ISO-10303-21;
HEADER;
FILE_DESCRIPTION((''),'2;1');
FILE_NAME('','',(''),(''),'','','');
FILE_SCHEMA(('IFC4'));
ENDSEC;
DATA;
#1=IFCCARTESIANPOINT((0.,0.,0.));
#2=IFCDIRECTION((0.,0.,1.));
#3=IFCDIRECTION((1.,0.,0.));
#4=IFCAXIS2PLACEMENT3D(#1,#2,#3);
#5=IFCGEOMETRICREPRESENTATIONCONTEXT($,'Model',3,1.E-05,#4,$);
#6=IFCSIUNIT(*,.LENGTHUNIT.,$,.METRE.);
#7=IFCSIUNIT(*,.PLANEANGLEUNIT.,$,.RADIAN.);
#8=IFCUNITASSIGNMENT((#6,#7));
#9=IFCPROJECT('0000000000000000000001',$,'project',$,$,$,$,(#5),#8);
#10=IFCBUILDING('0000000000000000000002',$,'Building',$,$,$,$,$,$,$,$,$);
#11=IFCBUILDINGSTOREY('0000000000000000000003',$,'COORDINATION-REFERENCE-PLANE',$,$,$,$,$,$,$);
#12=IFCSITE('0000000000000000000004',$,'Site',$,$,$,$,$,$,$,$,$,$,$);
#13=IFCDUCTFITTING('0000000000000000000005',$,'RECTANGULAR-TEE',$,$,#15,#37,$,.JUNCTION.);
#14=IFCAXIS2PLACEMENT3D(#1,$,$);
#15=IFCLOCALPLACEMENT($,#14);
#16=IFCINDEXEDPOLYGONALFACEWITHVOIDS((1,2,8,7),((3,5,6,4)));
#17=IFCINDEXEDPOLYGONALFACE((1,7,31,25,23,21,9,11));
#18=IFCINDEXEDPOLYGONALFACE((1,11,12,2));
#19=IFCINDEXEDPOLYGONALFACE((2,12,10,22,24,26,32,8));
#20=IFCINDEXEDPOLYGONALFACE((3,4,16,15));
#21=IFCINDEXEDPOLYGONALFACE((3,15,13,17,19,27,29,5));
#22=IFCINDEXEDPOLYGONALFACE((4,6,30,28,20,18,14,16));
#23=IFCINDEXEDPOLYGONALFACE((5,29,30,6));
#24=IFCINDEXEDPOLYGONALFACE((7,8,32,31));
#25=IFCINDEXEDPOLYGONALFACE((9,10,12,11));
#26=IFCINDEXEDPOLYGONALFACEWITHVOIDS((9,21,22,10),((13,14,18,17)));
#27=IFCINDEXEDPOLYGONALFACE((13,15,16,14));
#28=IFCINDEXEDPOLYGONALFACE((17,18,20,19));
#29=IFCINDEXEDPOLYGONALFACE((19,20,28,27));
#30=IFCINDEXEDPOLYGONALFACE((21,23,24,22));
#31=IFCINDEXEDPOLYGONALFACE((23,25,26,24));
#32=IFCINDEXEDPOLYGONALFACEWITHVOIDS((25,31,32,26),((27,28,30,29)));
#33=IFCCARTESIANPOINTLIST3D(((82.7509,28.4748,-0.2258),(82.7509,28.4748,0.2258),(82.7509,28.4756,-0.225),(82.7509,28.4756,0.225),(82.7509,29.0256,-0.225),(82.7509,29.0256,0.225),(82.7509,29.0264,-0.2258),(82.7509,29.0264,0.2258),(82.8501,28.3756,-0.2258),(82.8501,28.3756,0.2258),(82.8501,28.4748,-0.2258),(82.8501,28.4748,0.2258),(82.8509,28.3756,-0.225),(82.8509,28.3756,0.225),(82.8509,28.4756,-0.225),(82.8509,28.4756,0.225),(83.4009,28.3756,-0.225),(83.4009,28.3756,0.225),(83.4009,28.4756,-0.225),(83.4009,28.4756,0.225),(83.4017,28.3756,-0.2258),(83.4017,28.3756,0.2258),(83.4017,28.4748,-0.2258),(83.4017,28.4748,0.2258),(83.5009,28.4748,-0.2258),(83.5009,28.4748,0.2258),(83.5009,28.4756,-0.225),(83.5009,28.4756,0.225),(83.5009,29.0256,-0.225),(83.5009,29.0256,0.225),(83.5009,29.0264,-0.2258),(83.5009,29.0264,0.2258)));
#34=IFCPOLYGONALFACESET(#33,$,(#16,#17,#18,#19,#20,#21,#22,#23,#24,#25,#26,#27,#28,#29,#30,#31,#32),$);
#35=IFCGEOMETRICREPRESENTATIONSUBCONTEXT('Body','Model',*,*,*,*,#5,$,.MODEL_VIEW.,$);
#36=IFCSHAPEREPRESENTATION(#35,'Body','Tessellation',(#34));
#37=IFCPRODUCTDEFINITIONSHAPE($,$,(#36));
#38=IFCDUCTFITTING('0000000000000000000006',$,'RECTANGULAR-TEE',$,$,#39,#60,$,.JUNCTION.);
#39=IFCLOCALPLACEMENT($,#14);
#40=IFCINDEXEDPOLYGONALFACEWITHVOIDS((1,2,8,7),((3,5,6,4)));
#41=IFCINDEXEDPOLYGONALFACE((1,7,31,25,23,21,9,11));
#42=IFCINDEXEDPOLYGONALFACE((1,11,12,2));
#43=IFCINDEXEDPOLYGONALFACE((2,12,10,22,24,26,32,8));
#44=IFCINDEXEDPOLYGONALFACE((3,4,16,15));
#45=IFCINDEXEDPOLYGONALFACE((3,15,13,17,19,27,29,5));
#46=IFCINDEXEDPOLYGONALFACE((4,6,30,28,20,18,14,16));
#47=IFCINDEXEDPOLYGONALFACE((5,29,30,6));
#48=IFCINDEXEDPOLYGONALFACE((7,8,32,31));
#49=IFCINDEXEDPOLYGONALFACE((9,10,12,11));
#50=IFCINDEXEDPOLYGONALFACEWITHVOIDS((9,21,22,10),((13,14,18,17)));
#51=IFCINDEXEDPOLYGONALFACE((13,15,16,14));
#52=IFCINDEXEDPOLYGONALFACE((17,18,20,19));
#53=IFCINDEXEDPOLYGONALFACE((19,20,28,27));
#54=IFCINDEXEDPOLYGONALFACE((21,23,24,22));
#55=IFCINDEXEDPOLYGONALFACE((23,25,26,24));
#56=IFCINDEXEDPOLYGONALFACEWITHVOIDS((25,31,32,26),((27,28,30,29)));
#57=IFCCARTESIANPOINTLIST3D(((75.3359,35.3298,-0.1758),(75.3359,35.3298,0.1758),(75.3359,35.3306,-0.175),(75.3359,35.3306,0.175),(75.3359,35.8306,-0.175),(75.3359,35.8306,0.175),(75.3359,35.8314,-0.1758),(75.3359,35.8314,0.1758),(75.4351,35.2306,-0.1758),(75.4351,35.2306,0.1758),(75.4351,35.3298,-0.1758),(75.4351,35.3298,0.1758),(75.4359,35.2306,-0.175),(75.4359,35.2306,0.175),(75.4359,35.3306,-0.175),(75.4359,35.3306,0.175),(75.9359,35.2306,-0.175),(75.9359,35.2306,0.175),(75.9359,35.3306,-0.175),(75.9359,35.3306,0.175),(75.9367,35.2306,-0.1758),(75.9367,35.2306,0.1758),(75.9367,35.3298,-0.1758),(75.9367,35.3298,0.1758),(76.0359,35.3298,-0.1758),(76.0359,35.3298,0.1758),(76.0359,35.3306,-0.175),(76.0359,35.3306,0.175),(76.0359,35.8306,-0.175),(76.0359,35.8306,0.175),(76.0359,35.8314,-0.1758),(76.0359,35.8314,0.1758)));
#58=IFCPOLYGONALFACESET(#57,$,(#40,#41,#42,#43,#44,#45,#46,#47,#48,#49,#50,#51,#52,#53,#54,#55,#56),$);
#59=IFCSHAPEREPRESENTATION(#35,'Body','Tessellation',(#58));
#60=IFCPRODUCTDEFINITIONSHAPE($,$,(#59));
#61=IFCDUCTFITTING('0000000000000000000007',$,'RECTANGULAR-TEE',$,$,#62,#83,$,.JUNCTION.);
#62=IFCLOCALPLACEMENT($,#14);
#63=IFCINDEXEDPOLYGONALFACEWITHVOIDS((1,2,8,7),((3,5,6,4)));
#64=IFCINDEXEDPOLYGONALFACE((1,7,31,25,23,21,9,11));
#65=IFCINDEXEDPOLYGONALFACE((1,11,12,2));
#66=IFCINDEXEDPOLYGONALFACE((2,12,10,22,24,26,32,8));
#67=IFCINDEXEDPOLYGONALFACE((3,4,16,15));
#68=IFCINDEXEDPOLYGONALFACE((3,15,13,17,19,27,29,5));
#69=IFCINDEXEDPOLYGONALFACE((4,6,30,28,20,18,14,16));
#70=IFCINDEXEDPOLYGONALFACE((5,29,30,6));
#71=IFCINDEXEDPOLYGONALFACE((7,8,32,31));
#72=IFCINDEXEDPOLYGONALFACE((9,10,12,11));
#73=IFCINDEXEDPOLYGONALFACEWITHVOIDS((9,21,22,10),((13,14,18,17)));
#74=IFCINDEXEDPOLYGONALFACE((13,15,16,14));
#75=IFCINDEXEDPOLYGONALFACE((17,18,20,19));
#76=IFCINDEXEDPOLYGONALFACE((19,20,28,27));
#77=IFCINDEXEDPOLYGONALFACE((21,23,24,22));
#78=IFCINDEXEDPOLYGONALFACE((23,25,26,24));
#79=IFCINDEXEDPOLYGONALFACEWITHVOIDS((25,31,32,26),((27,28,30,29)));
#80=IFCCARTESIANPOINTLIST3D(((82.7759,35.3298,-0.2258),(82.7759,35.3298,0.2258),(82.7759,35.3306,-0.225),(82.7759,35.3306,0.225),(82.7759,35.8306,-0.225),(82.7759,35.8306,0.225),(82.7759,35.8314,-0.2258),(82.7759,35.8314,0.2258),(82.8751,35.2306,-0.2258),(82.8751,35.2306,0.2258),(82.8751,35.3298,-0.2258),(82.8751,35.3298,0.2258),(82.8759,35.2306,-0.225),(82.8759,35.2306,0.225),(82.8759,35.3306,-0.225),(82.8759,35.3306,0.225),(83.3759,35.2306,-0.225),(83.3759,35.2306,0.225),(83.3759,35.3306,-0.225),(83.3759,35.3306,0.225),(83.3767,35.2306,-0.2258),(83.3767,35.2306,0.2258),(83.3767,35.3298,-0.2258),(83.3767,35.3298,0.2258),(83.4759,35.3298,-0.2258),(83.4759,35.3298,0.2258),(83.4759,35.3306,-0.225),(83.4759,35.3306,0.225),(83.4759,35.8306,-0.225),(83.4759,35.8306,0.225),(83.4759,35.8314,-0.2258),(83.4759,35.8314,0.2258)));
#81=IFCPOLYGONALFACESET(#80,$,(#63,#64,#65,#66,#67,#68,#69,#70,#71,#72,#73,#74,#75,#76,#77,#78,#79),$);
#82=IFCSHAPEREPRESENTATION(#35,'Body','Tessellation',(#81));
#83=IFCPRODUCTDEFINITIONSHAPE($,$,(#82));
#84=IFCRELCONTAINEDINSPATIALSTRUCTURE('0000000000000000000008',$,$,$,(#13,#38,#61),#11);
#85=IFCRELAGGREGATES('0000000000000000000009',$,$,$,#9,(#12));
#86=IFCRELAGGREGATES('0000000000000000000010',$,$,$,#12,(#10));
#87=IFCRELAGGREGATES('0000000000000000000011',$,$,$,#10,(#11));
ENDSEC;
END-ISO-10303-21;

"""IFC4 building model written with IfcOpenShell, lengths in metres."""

from ifc_helpers import new_model, si_unit, frame, origin_with_axes, place, context, subcontext, project, spatial, rectangle, extrude, boolean, element, save


model = new_model("IFC4")

# Units and contexts
model_context = context("Model", 3, precision=1e-05, world=origin_with_axes())
body_context = subcontext(model_context, "Body", "Model", "MODEL_VIEW")
ifc_project = project(units=[si_unit("LENGTHUNIT", "METRE"), si_unit("PLANEANGLEUNIT", "RADIAN")], contexts=[model_context])

# Site, building, storey
site = spatial("IfcSite", under=ifc_project, Name="Site")
building = spatial("IfcBuilding", under=site, Name="Building")
storey = spatial("IfcBuildingStorey", under=building, Name="COORDINATION-REFERENCE-PLANE")

# Duct fittings
duct_fitting_1_placement = place(None, frame((83.1259, 28.7506, 0.0), z_axis=(-1.0, 0.0, 0.0), x_axis=(0.0, -1.0, 0.0)))
solid_1 = boolean("UNION", extrude(rectangle(XDim=0.55, YDim=0.45), frame((0.0, 0.0, -0.375), z_axis=(0.0, 0.0, 1.0), x_axis=(1.0, 0.0, 0.0)), (0.0, 0.0, 1.0), 0.75), extrude(rectangle(XDim=0.55, YDim=0.45), frame((0.0, 0.0, 0.0), z_axis=(1.0, 0.0, 0.0), x_axis=(0.0, 0.0, -1.0)), (0.0, 0.0, 1.0), 0.375))
element("IfcDuctFitting", 1, at=duct_fitting_1_placement, inside=storey, Name="RECTANGULAR-TEE", PredefinedType="JUNCTION", context=body_context, shape_type="CSG", body=[
    boolean("DIFFERENCE", boolean("UNION", extrude(rectangle(XDim=0.5516, YDim=0.4516), frame((0.0, 0.0, -0.375), z_axis=(0.0, 0.0, 1.0), x_axis=(1.0, 0.0, 0.0)), (0.0, 0.0, 1.0), 0.75), extrude(rectangle(XDim=0.5516, YDim=0.4516), frame((0.0, 0.0, 0.0), z_axis=(1.0, 0.0, 0.0), x_axis=(0.0, 0.0, -1.0)), (0.0, 0.0, 1.0), 0.375)), solid_1),
])
duct_fitting_2_placement = place(None, frame((75.6859, 35.5806, 0.0), z_axis=(-1.0, 0.0, 0.0), x_axis=(0.0, -1.0, 0.0)))
solid_2 = boolean("UNION", extrude(rectangle(XDim=0.5, YDim=0.35), frame((0.0, 0.0, -0.35), z_axis=(0.0, 0.0, 1.0), x_axis=(1.0, 0.0, 0.0)), (0.0, 0.0, 1.0), 0.7), extrude(rectangle(XDim=0.5, YDim=0.35), frame((0.0, 0.0, 0.0), z_axis=(1.0, 0.0, 0.0), x_axis=(0.0, 0.0, -1.0)), (0.0, 0.0, 1.0), 0.35))
element("IfcDuctFitting", 2, at=duct_fitting_2_placement, inside=storey, Name="RECTANGULAR-TEE", PredefinedType="JUNCTION", context=body_context, shape_type="CSG", body=[
    boolean("DIFFERENCE", boolean("UNION", extrude(rectangle(XDim=0.5016, YDim=0.3516), frame((0.0, 0.0, -0.35), z_axis=(0.0, 0.0, 1.0), x_axis=(1.0, 0.0, 0.0)), (0.0, 0.0, 1.0), 0.7), extrude(rectangle(XDim=0.5016, YDim=0.3516), frame((0.0, 0.0, 0.0), z_axis=(1.0, 0.0, 0.0), x_axis=(0.0, 0.0, -1.0)), (0.0, 0.0, 1.0), 0.35)), solid_2),
])
duct_fitting_3_placement = place(None, frame((83.1259, 35.5806, 0.0), z_axis=(-1.0, 0.0, 0.0), x_axis=(0.0, -1.0, 0.0)))
solid_3 = boolean("UNION", extrude(rectangle(XDim=0.5, YDim=0.45), frame((0.0, 0.0, -0.35), z_axis=(0.0, 0.0, 1.0), x_axis=(1.0, 0.0, 0.0)), (0.0, 0.0, 1.0), 0.7), extrude(rectangle(XDim=0.5, YDim=0.45), frame((0.0, 0.0, 0.0), z_axis=(1.0, 0.0, 0.0), x_axis=(0.0, 0.0, -1.0)), (0.0, 0.0, 1.0), 0.35))
element("IfcDuctFitting", 3, at=duct_fitting_3_placement, inside=storey, Name="RECTANGULAR-TEE", PredefinedType="JUNCTION", context=body_context, shape_type="CSG", body=[
    boolean("DIFFERENCE", boolean("UNION", extrude(rectangle(XDim=0.5016, YDim=0.4516), frame((0.0, 0.0, -0.35), z_axis=(0.0, 0.0, 1.0), x_axis=(1.0, 0.0, 0.0)), (0.0, 0.0, 1.0), 0.7), extrude(rectangle(XDim=0.5016, YDim=0.4516), frame((0.0, 0.0, 0.0), z_axis=(1.0, 0.0, 0.0), x_axis=(0.0, 0.0, -1.0)), (0.0, 0.0, 1.0), 0.35)), solid_3),
])

save(model, "model.ifc")
